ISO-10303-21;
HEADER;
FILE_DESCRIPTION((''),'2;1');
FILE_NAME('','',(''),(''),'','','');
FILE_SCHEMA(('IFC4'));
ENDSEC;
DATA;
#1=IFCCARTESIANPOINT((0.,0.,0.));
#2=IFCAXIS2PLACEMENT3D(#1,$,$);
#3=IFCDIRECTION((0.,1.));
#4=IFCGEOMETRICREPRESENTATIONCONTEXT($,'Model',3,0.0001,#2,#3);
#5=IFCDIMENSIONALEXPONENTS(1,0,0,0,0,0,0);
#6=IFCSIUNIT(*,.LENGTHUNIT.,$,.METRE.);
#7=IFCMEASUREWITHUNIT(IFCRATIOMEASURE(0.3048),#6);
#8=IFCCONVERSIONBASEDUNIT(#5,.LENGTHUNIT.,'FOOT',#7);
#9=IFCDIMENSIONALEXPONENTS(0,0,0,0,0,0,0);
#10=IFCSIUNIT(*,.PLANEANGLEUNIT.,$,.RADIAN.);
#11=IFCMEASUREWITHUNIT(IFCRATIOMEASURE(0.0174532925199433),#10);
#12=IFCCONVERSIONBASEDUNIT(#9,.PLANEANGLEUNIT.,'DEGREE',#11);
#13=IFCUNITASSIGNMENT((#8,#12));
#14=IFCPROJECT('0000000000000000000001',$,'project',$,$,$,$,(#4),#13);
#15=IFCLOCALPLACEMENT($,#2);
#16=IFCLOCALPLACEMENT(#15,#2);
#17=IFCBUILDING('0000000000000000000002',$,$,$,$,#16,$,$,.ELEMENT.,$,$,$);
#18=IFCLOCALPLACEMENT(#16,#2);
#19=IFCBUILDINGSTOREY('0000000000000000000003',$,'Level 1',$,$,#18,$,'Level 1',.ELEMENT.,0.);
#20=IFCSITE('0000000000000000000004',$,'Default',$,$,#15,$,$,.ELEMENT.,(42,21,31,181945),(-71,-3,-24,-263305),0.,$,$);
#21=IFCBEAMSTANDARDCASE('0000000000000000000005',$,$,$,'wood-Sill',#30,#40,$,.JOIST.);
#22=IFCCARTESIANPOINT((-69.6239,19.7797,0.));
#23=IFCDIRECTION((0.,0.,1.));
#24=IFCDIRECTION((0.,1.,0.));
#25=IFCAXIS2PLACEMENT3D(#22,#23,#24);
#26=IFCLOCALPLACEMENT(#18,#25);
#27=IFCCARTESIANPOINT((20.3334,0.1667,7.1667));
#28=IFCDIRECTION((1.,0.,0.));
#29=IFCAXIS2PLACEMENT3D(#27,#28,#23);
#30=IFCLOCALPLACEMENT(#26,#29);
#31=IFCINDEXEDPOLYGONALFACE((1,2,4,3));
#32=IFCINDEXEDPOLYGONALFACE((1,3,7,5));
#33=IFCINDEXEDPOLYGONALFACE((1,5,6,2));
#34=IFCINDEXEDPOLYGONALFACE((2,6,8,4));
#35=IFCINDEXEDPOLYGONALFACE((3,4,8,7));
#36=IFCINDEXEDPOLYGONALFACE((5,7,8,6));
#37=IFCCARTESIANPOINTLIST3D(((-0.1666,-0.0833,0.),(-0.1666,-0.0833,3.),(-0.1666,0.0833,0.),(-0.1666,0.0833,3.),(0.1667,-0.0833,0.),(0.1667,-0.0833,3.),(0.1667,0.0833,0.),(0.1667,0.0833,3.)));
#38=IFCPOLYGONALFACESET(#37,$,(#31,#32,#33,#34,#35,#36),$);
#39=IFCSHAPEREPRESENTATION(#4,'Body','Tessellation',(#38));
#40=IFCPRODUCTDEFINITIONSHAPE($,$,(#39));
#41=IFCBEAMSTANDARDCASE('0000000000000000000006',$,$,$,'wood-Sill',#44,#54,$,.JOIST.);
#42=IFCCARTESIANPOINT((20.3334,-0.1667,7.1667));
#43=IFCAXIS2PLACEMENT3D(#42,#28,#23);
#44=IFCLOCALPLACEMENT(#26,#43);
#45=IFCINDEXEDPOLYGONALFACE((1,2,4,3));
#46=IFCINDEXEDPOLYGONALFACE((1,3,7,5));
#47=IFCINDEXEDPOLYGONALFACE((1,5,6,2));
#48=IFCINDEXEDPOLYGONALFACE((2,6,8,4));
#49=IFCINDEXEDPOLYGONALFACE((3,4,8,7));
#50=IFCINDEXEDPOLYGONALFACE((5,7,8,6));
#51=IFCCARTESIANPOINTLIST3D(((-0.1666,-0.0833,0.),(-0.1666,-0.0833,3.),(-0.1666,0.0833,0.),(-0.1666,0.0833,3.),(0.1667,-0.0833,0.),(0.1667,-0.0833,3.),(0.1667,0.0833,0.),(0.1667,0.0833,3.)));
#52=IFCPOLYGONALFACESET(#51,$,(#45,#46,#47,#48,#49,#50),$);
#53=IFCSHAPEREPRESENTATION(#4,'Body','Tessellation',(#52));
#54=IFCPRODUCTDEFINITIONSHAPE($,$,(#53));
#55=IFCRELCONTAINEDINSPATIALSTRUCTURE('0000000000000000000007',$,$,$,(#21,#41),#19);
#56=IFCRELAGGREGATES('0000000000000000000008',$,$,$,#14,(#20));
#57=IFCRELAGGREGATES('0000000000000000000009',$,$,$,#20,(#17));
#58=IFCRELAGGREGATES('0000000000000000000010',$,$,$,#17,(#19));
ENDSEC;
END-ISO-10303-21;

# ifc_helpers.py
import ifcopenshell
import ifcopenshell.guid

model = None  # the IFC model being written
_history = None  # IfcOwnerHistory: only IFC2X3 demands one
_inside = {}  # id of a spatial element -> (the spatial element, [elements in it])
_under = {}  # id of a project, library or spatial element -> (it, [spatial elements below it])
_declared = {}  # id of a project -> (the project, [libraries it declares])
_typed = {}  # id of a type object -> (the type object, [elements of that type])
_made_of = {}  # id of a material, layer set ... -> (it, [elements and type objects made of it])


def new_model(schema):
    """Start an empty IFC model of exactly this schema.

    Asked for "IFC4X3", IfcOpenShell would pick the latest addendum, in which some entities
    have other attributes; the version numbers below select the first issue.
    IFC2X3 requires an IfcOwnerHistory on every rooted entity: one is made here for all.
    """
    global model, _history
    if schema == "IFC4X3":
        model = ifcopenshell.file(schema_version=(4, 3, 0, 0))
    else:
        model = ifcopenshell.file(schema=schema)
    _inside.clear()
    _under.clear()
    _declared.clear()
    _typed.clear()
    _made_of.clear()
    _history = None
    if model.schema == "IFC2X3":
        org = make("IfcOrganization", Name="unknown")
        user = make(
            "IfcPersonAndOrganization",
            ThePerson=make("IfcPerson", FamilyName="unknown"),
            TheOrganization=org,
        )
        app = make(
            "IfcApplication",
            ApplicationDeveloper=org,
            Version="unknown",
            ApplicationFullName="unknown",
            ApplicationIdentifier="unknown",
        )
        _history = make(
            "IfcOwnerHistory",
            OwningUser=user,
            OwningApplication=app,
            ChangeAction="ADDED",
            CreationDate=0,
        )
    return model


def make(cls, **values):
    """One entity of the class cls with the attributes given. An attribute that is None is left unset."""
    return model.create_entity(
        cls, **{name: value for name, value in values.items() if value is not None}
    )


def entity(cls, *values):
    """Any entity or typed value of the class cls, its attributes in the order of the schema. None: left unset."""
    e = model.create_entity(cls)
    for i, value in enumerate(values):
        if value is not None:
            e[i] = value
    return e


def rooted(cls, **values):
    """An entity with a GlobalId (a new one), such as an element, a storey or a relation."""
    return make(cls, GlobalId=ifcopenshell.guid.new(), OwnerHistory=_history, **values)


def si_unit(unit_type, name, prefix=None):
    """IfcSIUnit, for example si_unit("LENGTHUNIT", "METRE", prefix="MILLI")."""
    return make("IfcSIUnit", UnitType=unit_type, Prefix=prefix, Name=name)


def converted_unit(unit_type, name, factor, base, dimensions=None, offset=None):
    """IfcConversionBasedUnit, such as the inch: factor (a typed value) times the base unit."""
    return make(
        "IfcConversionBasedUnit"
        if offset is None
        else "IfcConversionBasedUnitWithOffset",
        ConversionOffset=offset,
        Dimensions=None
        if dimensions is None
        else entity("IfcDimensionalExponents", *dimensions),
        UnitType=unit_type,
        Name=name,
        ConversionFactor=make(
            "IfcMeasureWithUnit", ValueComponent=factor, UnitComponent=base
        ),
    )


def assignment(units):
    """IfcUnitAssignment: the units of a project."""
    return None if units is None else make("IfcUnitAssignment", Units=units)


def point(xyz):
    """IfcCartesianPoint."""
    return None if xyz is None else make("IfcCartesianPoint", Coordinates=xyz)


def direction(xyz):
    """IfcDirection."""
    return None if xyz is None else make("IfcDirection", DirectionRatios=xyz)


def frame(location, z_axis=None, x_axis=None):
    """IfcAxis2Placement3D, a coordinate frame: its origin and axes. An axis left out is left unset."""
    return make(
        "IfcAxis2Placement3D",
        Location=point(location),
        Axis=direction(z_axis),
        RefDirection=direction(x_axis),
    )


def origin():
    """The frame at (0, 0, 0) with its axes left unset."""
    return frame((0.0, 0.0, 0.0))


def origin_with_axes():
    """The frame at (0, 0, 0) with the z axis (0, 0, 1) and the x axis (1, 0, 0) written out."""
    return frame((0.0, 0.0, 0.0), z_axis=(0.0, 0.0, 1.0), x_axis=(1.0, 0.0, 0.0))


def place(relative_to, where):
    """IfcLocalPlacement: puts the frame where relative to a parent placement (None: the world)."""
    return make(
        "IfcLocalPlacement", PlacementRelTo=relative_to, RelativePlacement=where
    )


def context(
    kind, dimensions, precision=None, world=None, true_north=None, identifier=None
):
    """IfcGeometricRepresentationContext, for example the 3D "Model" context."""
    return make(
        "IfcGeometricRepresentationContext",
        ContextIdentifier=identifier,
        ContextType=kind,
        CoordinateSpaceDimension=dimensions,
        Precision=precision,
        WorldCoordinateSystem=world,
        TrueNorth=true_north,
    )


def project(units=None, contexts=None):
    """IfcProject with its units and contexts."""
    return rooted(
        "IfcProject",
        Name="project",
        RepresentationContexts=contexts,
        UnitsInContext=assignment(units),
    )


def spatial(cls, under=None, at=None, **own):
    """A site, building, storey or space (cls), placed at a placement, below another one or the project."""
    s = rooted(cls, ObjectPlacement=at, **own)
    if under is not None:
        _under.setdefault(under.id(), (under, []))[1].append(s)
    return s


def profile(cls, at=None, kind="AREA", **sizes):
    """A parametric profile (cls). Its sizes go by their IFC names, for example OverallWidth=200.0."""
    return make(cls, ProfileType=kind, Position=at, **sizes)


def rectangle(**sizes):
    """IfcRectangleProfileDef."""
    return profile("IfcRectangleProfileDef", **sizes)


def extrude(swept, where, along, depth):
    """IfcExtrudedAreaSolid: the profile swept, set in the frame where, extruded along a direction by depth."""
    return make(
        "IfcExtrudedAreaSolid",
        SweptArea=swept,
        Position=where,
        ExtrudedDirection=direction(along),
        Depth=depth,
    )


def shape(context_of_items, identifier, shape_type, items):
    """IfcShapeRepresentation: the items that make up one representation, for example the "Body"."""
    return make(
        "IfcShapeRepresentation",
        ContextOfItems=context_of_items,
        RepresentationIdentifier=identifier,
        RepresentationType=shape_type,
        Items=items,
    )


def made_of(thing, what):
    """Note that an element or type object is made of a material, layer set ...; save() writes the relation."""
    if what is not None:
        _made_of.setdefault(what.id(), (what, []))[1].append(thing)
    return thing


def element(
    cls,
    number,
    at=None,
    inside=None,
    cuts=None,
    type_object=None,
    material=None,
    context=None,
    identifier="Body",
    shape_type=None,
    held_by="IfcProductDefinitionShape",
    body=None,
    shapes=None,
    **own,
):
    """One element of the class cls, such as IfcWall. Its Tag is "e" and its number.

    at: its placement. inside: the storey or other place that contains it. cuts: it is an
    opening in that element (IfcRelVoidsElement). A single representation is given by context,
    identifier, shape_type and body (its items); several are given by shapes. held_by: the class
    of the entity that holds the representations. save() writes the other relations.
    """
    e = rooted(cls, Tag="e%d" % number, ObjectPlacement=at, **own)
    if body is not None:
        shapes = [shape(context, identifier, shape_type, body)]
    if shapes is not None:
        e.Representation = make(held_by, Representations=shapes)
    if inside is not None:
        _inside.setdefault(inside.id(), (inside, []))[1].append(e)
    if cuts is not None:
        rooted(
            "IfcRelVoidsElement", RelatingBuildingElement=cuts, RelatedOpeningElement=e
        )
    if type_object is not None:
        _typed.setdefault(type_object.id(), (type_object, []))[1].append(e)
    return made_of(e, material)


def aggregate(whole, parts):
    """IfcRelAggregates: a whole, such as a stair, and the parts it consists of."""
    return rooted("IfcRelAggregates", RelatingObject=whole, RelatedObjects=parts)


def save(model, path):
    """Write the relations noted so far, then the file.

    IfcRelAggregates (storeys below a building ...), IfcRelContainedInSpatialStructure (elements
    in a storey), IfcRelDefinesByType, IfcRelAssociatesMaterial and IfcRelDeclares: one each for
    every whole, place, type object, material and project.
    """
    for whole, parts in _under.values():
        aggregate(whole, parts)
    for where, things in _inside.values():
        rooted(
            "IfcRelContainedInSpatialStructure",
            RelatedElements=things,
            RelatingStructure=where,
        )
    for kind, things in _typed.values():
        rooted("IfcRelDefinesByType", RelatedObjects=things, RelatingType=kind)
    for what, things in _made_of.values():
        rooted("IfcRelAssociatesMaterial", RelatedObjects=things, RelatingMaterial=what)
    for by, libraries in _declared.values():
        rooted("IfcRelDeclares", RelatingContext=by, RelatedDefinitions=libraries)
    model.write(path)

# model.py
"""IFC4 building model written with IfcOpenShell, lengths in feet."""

from ifc_helpers import new_model, entity, si_unit, converted_unit, direction, frame, origin, origin_with_axes, place, context, project, spatial, rectangle, extrude, element, save


model = new_model("IFC4")

# Units and contexts
model_context = context("Model", 3, precision=0.0001, world=origin(), true_north=direction((0.0, 1.0)))
ifc_project = project(units=[converted_unit("LENGTHUNIT", "FOOT", entity("IfcRatioMeasure", 0.3048), si_unit("LENGTHUNIT", "METRE"), dimensions=[1, 0, 0, 0, 0, 0, 0]), converted_unit("PLANEANGLEUNIT", "DEGREE", entity("IfcRatioMeasure", 0.0174532925199433), si_unit("PLANEANGLEUNIT", "RADIAN"), dimensions=[0, 0, 0, 0, 0, 0, 0])], contexts=[model_context])

# Site, building, storey
site_placement = place(None, origin())
site = spatial("IfcSite", under=ifc_project, at=site_placement, Name="Default", CompositionType="ELEMENT", RefLatitude=(42, 21, 31, 181945), RefLongitude=(-71, -3, -24, -263305), RefElevation=0.0)
building_placement = place(site_placement, origin())
building = spatial("IfcBuilding", under=site, at=building_placement, CompositionType="ELEMENT")
storey_placement = place(building_placement, origin())
storey = spatial("IfcBuildingStorey", under=building, at=storey_placement, Name="Level 1", LongName="Level 1", CompositionType="ELEMENT", Elevation=0.0)

# Shared definitions
placement_1 = place(storey_placement, frame((-69.6239, 19.7797, 0.0), z_axis=(0.0, 0.0, 1.0), x_axis=(0.0, 1.0, 0.0)))

# Beams
for number, where, z_axis, x_axis in (
    (1, (20.3334, 0.1667, 7.1667), (1.0, 0.0, 0.0), (0.0, 0.0, 1.0)),
    (2, (20.3334, -0.1667, 7.1667), (1.0, 0.0, 0.0), (0.0, 0.0, 1.0)),
):
    element("IfcBeamStandardCase", number, at=place(placement_1, frame(where, z_axis=z_axis, x_axis=x_axis)), inside=storey, ObjectType="wood-Sill", PredefinedType="JOIST", context=model_context, shape_type="SweptSolid", body=[
        extrude(rectangle(XDim=0.3333, YDim=0.1667), origin_with_axes(), (0.0, 0.0, 1.0), 3.0),
    ])

save(model, "model.ifc")
